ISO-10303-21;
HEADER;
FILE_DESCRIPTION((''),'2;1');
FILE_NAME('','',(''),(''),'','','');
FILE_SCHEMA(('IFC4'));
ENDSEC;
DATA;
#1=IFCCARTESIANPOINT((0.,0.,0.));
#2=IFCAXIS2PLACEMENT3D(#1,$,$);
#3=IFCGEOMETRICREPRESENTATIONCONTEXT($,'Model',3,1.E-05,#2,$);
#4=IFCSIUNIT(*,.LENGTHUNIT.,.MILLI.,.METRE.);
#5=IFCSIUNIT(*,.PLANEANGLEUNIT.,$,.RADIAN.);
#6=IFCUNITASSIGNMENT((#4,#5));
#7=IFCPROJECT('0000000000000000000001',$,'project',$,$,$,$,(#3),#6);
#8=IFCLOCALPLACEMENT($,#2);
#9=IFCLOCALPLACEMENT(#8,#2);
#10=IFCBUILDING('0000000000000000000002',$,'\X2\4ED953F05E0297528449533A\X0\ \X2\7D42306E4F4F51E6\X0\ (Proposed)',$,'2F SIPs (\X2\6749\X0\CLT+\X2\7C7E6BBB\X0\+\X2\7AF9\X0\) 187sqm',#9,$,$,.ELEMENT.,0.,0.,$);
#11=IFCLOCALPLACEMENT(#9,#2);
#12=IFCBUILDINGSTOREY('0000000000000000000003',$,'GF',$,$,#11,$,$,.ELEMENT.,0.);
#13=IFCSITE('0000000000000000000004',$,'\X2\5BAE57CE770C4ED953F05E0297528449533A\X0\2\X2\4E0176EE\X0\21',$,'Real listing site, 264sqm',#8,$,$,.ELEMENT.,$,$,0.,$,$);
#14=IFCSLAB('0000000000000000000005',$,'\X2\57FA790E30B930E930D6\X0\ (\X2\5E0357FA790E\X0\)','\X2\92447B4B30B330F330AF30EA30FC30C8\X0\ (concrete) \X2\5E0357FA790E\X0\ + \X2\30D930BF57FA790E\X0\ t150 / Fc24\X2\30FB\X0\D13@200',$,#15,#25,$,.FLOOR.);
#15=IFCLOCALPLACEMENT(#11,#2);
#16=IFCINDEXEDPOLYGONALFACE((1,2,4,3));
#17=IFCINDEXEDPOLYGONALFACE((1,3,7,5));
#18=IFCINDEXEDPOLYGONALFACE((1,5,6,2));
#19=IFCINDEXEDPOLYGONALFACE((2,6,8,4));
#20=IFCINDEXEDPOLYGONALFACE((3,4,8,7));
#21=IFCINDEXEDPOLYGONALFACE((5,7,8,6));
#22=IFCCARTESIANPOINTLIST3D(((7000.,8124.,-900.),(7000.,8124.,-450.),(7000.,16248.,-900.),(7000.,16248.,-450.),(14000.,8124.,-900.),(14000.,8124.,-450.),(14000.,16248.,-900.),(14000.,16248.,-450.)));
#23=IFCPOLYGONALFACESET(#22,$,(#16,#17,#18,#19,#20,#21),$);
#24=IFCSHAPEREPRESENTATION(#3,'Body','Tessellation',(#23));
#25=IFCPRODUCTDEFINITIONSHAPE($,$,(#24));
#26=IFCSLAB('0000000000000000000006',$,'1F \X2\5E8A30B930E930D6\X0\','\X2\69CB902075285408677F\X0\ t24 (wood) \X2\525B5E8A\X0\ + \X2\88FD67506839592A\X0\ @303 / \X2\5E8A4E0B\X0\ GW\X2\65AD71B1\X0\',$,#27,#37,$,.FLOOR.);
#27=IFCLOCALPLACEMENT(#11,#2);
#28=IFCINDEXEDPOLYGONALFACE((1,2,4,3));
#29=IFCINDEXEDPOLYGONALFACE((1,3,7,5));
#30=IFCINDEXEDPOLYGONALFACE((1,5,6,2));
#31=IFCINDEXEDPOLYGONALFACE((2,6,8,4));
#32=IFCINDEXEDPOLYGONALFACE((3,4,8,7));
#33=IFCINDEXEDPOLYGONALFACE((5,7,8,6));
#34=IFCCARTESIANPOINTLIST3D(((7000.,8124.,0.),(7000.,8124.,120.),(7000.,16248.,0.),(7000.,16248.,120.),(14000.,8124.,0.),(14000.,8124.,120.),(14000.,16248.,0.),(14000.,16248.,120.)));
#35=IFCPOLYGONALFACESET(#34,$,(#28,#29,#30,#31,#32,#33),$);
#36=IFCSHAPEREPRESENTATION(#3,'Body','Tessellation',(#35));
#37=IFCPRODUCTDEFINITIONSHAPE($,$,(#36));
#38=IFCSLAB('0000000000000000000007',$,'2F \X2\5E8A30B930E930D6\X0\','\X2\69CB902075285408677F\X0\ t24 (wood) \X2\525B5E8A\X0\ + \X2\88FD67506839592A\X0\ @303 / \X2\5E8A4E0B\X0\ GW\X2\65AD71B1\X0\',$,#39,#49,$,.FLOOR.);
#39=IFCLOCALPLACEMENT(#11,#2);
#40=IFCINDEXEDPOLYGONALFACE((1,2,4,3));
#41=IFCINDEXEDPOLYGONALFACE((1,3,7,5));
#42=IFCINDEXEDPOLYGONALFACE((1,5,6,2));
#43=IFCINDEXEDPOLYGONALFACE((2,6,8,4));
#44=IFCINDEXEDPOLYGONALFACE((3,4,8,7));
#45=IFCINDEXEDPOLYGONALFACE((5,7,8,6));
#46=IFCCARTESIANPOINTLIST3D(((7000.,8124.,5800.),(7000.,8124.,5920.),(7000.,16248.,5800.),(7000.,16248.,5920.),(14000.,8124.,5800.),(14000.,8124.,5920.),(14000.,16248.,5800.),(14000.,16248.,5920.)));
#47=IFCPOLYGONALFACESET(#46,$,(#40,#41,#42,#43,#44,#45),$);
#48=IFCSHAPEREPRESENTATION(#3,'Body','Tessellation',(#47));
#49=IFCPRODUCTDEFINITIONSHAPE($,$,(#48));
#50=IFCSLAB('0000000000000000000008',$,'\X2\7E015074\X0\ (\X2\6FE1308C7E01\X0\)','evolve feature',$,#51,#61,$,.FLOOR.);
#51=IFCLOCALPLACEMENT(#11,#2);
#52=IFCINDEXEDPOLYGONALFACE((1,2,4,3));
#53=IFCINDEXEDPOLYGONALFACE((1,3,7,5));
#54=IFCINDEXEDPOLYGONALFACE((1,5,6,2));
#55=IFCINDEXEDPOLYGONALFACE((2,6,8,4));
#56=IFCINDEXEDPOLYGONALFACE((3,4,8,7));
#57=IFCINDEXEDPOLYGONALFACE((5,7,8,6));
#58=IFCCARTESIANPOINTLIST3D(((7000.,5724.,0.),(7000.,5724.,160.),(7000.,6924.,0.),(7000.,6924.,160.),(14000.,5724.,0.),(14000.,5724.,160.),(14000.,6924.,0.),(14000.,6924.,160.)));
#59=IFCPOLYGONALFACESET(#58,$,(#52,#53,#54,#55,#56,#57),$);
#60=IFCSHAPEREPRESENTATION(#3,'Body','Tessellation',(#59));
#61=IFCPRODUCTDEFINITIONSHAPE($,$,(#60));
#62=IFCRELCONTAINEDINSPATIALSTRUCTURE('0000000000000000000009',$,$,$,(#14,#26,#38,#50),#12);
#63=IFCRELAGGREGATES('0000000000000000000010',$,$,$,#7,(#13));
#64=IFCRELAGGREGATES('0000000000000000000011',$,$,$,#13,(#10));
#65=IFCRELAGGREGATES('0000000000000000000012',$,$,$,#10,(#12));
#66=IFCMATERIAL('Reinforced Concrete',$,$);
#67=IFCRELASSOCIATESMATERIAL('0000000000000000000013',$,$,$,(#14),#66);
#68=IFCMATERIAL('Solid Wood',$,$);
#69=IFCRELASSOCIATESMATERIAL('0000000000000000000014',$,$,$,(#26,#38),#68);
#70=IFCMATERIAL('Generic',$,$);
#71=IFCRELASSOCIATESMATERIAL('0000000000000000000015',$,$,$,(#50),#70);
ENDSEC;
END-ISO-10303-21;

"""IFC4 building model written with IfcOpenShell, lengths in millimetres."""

from ifc_helpers import new_model, si_unit, frame, frame_2d, origin, place, context, project, spatial, rectangle, extrude, material, element, save


model = new_model("IFC4")

# Units and contexts
model_context = context("Model", 3, precision=1e-05, world=origin())
ifc_project = project(units=[si_unit("LENGTHUNIT", "METRE", prefix="MILLI"), si_unit("PLANEANGLEUNIT", "RADIAN")], contexts=[model_context])

# Site, building, storey
site_placement = place(None, origin())
site = spatial("IfcSite", under=ifc_project, at=site_placement, Name="宮城県仙台市青葉区2丁目21", ObjectType="Real listing site, 264sqm", CompositionType="ELEMENT", RefElevation=0.0)
building_placement = place(site_placement, origin())
building = spatial("IfcBuilding", under=site, at=building_placement, Name="仙台市青葉区 終の住処 (Proposed)", ObjectType="2F SIPs (杉CLT+籾殻+竹) 187sqm", CompositionType="ELEMENT", ElevationOfRefHeight=0.0, ElevationOfTerrain=0.0)
storey_placement = place(building_placement, origin())
storey = spatial("IfcBuildingStorey", under=building, at=storey_placement, Name="GF", CompositionType="ELEMENT", Elevation=0.0)

# Slabs
ifc_material_1 = material(Name="Reinforced Concrete")
slab_1_placement = place(storey_placement, frame((3500.0, 4062.0, -450.0)))
element("IfcSlab", 1, at=slab_1_placement, inside=storey, material=ifc_material_1, Name="基礎スラブ (布基礎)", Description="鉄筋コンクリート (concrete) 布基礎 + ベタ基礎 t150 / Fc24・D13@200", PredefinedType="FLOOR", context=model_context, shape_type="SweptSolid", body=[
    extrude(rectangle(XDim=7000.0, YDim=8124.0, at=frame_2d((3500.0, 4062.0))), frame((3500.0, 4062.0, -450.0)), (0.0, 0.0, 1.0), 450.0),
])
ifc_material_2 = material(Name="Solid Wood")
slab_2_placement = place(storey_placement, frame((3500.0, 4062.0, 0.0)))
element("IfcSlab", 2, at=slab_2_placement, inside=storey, material=ifc_material_2, Name="1F 床スラブ", Description="構造用合板 t24 (wood) 剛床 + 製材根太 @303 / 床下 GW断熱", PredefinedType="FLOOR", context=model_context, shape_type="SweptSolid", body=[
    extrude(rectangle(XDim=7000.0, YDim=8124.0, at=frame_2d((3500.0, 4062.0))), frame((3500.0, 4062.0, 0.0)), (0.0, 0.0, 1.0), 120.0),
])
slab_3_placement = place(storey_placement, frame((3500.0, 4062.0, 2900.0)))
element("IfcSlab", 3, at=slab_3_placement, inside=storey, material=ifc_material_2, Name="2F 床スラブ", Description="構造用合板 t24 (wood) 剛床 + 製材根太 @303 / 床下 GW断熱", PredefinedType="FLOOR", context=model_context, shape_type="SweptSolid", body=[
    extrude(rectangle(XDim=7000.0, YDim=8124.0, at=frame_2d((3500.0, 4062.0))), frame((3500.0, 4062.0, 2900.0)), (0.0, 0.0, 1.0), 120.0),
])
ifc_material_3 = material(Name="Generic")
slab_4_placement = place(storey_placement, frame((3500.0, 2862.0, 0.0)))
element("IfcSlab", 4, at=slab_4_placement, inside=storey, material=ifc_material_3, Name="縁側 (濡れ縁)", Description="evolve feature", PredefinedType="FLOOR", context=model_context, shape_type="SweptSolid", body=[
    extrude(rectangle(XDim=7000.0, YDim=1200.0, at=frame_2d((3500.0, 600.0))), frame((3500.0, 2862.0, 0.0)), (0.0, 0.0, 1.0), 160.0),
])

save(model, "model.ifc")
